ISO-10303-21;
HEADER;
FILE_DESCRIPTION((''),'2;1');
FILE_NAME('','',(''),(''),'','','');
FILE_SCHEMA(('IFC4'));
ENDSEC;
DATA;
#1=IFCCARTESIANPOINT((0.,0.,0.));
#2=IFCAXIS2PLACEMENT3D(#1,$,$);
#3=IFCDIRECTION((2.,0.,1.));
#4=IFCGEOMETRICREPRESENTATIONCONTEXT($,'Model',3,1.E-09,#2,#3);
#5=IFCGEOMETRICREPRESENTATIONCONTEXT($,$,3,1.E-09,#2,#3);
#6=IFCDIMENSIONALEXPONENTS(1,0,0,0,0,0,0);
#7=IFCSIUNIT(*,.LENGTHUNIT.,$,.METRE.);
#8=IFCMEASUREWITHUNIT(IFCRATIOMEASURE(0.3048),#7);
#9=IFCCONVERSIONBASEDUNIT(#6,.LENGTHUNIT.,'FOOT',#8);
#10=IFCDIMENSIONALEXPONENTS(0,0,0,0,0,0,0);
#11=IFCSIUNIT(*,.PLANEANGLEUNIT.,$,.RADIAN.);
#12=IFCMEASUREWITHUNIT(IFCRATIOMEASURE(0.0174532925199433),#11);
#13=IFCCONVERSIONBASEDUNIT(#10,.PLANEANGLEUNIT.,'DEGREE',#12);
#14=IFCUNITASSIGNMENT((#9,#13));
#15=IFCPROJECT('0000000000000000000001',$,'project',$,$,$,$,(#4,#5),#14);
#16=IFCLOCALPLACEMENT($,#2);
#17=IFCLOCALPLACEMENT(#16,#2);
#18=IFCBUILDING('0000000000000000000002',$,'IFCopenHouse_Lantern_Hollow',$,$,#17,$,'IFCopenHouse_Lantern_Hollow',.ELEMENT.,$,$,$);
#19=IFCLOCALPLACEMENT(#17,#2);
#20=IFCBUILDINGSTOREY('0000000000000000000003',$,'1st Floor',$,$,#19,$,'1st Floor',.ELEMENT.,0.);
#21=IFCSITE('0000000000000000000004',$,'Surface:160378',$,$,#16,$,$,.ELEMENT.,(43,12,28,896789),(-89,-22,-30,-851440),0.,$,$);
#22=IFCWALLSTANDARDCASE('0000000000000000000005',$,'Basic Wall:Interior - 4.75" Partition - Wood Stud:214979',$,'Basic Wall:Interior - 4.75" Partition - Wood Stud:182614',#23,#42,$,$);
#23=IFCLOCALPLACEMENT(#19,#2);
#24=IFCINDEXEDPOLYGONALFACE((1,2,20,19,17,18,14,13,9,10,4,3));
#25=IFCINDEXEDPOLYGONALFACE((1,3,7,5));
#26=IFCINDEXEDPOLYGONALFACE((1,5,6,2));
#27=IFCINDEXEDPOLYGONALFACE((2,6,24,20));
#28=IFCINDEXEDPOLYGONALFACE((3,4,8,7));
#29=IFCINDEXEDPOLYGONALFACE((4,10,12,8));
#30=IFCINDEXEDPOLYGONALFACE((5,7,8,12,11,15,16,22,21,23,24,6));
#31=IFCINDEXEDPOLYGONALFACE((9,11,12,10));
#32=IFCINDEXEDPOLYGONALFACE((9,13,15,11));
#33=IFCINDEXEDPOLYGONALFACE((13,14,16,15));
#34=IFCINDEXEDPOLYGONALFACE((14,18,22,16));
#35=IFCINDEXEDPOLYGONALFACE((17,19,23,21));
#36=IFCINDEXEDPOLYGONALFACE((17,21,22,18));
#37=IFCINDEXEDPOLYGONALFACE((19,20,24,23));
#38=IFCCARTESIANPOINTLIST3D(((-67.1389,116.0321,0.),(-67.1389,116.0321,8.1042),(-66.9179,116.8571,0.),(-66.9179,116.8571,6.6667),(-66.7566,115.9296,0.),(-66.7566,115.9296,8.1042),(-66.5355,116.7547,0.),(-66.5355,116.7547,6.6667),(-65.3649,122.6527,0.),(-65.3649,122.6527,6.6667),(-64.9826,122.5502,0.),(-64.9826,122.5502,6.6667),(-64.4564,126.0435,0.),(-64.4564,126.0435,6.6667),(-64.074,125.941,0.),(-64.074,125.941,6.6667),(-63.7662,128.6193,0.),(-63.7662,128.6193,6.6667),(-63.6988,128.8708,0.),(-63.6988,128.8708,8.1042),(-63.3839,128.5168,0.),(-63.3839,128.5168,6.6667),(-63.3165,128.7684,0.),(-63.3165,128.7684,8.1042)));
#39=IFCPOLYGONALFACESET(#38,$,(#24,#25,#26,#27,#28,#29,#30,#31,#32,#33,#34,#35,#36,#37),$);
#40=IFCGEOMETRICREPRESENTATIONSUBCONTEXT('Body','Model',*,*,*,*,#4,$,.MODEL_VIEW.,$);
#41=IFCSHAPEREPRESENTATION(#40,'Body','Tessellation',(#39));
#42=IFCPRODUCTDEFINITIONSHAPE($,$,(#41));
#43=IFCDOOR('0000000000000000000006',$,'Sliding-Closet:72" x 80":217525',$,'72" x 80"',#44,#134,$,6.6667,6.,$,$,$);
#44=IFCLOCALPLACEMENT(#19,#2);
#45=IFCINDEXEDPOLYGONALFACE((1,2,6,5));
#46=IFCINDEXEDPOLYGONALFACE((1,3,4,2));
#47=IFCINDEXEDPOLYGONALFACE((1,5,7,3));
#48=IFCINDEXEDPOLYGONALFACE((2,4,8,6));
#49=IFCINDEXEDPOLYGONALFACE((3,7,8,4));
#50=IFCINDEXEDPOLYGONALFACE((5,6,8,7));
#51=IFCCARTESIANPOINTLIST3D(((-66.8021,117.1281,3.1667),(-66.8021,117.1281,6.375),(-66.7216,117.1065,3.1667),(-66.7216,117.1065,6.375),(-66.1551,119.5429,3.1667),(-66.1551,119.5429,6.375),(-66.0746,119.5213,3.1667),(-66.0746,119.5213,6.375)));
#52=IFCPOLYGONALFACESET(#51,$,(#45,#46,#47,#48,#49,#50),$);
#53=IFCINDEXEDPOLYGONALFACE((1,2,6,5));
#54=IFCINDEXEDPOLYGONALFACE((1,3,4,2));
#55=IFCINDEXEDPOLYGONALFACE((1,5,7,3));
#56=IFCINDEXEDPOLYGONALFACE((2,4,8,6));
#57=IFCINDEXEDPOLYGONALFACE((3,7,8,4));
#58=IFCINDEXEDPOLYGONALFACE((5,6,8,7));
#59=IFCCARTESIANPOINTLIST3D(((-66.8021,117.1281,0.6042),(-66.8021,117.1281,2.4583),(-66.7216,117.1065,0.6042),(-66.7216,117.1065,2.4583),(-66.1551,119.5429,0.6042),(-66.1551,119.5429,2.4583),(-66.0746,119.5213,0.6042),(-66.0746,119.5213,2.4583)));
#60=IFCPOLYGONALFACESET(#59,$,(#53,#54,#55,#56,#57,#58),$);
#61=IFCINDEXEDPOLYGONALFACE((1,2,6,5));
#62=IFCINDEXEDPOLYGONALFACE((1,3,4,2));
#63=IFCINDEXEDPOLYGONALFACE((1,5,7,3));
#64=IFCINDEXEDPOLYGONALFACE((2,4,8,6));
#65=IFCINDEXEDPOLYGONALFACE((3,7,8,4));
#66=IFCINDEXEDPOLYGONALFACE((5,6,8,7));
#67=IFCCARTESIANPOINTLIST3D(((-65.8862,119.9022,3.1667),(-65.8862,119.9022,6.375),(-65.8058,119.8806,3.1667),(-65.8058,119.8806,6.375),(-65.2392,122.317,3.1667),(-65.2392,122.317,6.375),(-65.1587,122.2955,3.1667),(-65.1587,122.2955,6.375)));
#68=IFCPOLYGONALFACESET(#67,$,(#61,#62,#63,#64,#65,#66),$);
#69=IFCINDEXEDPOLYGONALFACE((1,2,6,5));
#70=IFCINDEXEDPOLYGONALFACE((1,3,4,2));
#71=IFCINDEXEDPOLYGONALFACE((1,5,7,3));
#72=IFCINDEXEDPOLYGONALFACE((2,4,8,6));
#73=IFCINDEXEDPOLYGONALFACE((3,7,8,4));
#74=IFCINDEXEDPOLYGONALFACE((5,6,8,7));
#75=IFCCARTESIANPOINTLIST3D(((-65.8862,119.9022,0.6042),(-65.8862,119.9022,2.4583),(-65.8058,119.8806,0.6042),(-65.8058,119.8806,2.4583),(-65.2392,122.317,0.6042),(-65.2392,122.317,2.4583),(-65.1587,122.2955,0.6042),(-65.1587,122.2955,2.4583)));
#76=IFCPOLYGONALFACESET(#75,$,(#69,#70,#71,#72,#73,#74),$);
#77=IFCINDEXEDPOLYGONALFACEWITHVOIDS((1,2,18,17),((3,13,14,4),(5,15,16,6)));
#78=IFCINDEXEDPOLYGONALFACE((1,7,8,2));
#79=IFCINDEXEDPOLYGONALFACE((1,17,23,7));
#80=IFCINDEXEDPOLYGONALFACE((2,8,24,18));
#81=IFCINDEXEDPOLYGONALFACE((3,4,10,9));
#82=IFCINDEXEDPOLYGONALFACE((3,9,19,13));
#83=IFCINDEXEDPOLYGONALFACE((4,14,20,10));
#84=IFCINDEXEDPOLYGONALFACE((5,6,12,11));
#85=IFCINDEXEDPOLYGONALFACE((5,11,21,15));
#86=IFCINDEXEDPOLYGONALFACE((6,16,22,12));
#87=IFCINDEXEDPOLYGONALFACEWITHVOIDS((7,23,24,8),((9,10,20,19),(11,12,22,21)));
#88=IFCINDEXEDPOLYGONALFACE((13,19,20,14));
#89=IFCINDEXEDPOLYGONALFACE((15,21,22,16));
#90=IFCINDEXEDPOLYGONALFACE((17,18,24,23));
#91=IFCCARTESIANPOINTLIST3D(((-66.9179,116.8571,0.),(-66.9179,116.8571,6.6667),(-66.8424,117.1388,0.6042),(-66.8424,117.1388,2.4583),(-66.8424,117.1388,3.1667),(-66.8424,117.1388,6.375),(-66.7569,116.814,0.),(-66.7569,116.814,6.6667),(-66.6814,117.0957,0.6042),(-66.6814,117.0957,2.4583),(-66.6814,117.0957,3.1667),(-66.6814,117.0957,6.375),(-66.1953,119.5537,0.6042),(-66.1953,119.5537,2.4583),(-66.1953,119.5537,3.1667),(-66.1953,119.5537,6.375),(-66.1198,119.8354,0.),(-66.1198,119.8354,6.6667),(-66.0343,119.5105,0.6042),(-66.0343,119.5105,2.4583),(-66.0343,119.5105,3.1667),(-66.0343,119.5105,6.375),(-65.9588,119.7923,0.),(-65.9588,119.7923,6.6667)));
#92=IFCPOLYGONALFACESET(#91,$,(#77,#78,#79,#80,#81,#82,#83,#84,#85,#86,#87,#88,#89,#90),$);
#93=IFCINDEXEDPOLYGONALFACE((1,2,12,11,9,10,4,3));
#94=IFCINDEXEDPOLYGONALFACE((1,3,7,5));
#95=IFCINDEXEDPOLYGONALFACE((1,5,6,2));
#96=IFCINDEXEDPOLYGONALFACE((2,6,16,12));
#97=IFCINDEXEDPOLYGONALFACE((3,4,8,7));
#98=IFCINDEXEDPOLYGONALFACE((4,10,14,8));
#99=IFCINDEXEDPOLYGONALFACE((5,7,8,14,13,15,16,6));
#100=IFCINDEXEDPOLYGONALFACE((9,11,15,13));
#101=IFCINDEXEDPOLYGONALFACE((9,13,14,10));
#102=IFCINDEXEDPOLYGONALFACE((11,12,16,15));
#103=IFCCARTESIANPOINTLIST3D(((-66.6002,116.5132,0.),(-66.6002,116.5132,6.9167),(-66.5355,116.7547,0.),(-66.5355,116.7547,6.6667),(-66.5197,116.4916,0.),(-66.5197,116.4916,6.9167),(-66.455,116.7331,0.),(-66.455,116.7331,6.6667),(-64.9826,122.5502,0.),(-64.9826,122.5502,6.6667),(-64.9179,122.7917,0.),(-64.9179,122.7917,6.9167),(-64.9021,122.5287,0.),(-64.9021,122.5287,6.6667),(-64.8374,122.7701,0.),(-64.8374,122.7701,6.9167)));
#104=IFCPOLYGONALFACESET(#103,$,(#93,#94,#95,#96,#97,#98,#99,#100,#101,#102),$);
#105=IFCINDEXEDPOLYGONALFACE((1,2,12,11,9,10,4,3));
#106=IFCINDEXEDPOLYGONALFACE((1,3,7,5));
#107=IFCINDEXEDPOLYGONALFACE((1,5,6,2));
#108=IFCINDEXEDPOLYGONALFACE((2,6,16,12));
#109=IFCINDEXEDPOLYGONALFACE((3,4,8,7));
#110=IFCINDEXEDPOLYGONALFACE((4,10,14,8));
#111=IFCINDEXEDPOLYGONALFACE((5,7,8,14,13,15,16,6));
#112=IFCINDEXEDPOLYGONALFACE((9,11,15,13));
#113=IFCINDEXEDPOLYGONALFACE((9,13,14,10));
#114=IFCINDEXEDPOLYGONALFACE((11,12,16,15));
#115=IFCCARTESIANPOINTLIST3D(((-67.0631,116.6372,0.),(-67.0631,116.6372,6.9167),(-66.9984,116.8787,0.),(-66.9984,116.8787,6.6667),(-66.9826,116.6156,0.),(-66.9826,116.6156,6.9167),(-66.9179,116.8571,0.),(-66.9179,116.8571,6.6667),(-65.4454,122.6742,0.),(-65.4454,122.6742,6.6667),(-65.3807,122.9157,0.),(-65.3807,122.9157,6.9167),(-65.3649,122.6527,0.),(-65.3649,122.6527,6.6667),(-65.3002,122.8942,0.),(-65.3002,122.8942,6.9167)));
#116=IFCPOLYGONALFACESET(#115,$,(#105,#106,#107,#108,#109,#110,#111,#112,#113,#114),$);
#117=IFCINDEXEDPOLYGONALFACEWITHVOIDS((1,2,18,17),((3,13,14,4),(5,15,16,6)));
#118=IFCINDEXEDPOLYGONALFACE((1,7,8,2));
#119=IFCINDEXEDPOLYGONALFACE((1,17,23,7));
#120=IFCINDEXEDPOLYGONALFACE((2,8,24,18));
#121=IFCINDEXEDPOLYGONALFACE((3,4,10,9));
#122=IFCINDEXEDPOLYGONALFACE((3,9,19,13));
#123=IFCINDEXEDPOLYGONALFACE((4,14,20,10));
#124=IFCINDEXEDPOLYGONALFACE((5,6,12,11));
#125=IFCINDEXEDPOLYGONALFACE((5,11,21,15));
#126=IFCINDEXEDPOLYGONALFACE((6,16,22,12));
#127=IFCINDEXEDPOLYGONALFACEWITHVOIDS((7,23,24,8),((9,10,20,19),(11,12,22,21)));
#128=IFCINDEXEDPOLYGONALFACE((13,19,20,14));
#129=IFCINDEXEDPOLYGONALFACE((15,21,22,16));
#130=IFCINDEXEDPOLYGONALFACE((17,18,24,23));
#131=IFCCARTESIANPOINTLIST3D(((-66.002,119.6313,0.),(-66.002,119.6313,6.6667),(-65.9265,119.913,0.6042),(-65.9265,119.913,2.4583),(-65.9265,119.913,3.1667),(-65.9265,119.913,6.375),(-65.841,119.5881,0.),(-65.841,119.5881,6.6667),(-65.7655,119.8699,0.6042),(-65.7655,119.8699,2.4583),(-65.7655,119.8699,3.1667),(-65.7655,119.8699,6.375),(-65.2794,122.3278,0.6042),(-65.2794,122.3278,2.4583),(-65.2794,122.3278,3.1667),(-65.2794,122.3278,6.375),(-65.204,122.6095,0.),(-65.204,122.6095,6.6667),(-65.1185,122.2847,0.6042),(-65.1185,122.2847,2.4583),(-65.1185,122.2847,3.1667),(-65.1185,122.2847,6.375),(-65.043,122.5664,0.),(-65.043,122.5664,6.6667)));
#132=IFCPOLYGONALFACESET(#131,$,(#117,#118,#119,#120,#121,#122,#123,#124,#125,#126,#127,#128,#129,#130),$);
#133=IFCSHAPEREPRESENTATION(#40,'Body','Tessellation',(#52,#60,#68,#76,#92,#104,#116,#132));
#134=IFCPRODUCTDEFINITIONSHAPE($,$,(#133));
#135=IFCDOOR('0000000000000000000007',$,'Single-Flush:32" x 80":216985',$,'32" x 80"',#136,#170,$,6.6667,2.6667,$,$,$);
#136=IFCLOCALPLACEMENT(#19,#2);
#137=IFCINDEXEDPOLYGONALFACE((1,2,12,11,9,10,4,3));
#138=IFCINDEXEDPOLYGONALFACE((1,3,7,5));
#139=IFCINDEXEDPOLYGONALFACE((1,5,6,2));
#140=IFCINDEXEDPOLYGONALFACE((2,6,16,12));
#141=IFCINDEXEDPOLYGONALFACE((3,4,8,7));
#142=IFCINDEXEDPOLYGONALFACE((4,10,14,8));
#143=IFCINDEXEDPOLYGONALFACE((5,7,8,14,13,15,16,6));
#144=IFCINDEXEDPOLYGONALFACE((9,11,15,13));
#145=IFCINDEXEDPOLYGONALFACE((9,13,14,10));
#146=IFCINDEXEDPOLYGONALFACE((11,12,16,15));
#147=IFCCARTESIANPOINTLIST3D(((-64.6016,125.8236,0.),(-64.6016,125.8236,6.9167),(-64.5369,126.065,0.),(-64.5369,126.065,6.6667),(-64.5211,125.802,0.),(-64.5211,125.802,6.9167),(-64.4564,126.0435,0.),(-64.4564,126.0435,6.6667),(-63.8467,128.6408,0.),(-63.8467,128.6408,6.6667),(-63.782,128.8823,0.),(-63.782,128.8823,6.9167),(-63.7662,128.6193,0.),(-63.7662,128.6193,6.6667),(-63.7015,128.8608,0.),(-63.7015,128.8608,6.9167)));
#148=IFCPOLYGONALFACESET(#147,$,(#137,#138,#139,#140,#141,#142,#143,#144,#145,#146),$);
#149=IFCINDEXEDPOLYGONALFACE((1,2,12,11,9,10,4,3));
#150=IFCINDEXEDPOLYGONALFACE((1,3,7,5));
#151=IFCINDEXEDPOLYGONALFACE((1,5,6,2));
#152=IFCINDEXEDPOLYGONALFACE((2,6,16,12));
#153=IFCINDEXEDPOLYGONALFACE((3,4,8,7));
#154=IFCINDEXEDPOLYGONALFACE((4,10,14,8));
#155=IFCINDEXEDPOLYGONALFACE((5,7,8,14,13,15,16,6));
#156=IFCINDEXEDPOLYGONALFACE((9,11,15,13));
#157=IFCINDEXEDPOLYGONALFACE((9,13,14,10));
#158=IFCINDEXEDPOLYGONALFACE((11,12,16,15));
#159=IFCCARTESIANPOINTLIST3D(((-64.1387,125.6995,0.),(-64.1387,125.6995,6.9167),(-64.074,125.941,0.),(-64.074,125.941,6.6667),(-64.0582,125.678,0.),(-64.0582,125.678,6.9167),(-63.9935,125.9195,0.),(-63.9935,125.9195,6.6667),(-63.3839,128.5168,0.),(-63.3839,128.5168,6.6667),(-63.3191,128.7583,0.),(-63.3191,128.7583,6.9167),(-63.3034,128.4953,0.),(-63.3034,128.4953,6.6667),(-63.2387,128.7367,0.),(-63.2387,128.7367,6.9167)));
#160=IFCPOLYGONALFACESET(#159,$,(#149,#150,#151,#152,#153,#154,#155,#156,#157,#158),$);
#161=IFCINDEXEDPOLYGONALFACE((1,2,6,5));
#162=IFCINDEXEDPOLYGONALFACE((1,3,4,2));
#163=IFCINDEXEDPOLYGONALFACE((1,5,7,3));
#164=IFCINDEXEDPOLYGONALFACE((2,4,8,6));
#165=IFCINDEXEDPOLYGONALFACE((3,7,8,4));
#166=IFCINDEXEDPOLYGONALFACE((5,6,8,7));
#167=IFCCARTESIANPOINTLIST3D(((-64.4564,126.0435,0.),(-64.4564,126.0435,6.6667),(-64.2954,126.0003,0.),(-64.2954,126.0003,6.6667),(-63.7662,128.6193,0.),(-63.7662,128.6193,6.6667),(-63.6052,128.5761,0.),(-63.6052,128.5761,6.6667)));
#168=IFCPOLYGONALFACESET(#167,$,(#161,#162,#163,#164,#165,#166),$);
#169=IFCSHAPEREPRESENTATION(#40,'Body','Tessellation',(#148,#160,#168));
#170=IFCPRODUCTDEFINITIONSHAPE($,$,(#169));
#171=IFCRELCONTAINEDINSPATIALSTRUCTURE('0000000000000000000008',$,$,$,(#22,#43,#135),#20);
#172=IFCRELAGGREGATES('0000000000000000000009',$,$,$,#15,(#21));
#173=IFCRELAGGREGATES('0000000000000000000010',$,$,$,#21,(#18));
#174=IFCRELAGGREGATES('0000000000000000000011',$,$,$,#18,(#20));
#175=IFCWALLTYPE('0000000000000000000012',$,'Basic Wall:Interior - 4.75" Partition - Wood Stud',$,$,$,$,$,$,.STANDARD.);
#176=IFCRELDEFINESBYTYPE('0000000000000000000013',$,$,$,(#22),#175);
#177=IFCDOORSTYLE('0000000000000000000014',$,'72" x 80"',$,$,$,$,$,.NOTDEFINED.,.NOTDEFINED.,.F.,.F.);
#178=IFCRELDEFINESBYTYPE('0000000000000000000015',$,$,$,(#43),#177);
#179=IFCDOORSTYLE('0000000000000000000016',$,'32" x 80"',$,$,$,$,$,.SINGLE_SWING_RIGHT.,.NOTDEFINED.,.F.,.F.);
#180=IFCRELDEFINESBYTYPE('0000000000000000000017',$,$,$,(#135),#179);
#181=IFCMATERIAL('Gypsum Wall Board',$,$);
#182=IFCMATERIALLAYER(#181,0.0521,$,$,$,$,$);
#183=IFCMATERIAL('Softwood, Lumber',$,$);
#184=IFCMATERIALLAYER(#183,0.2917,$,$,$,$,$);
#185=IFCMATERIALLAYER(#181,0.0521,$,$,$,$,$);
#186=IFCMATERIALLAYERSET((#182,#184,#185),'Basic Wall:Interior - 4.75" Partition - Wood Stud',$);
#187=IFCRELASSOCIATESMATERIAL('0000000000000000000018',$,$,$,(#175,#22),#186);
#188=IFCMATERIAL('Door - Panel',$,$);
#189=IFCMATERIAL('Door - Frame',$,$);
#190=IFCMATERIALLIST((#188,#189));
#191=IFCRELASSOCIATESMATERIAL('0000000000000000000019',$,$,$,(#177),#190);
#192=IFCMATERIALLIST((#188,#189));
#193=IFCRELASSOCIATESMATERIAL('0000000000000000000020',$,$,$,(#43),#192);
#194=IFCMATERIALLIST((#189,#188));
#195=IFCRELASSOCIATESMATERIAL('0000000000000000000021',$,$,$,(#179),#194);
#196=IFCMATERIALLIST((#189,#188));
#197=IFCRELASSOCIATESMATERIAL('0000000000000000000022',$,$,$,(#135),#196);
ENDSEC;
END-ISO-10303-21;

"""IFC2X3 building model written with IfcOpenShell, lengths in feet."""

from ifc_helpers import new_model, entity, si_unit, converted_unit, direction, frame, frame_2d, origin, origin_2d_with_axis, place, context, subcontext, project, spatial, polyline, rectangle, outline, extrude, source, transform, mapped, material, material_list, layer, layer_set, layer_usage, type_object, type_shapes, element, fill, save


model = new_model("IFC2X3")

# Units and contexts
model_context = context("Model", 3, precision=1e-09, world=origin(), true_north=direction((2.0, 0.0, 1.0)))
context_of_model = context(None, 3, precision=1e-09, world=origin(), true_north=direction((2.0, 0.0, 1.0)))
body_context = subcontext(model_context, "Body", "Model", "MODEL_VIEW")
ifc_project = project(units=[converted_unit("LENGTHUNIT", "FOOT", entity("IfcRatioMeasure", 0.3048), si_unit("LENGTHUNIT", "METRE"), dimensions=[1, 0, 0, 0, 0, 0, 0]), converted_unit("PLANEANGLEUNIT", "DEGREE", entity("IfcRatioMeasure", 0.0174532925199433), si_unit("PLANEANGLEUNIT", "RADIAN"), dimensions=[0, 0, 0, 0, 0, 0, 0])], contexts=[model_context, context_of_model])

# Site, building, storey
site_placement = place(None, origin())
site = spatial("IfcSite", under=ifc_project, at=site_placement, Name="Surface:160378", CompositionType="ELEMENT", RefLatitude=(43, 12, 28, 896789), RefLongitude=(-89, -22, -30, -851440), RefElevation=0.0)
building_placement = place(site_placement, origin())
building = spatial("IfcBuilding", under=site, at=building_placement, Name="IFCopenHouse_Lantern_Hollow", LongName="IFCopenHouse_Lantern_Hollow", CompositionType="ELEMENT")
storey_placement = place(building_placement, origin())
storey = spatial("IfcBuildingStorey", under=building, at=storey_placement, Name="1st Floor", LongName="1st Floor", CompositionType="ELEMENT", Elevation=0.0)

# Shared definitions
ifc_material_1 = material(Name="Softwood, Lumber")

# Shared definitions
ifc_material_2 = material(Name="Gypsum Wall Board")

# Shared definitions
ifc_layer_1 = layer(ifc_material_2, 0.0521)
ifc_layer_2 = layer(ifc_material_1, 0.2917)
ifc_layer_3 = layer(ifc_material_2, 0.0521)
ifc_layer_set_1 = layer_set([ifc_layer_1, ifc_layer_2, ifc_layer_3], Name="Basic Wall:Interior - 4.75\" Partition - Wood Stud")
wall_type_1 = type_object("IfcWallType", Name="Basic Wall:Interior - 4.75\" Partition - Wood Stud", PredefinedType="STANDARD", material=ifc_layer_set_1)

# Shared definitions
ifc_material_3 = material(Name="Door - Panel")
ifc_material_4 = material(Name="Door - Frame")
ifc_material_list_1 = material_list([ifc_material_3, ifc_material_4])
door_style_1 = type_object("IfcDoorStyle", Name="72\" x 80\"", ConstructionType="NOTDEFINED", OperationType="NOTDEFINED", ParameterTakesPrecedence=False, Sizeable=False, material=ifc_material_list_1)
shared_shape_1 = source(origin(), body_context, "Body", "SweptSolid", [
    extrude(rectangle(XDim=0.0833, YDim=2.5, at=origin_2d_with_axis()), frame((1.5417, 0.3125, 3.1667), z_axis=(0.0, 0.0, 1.0), x_axis=(0.0, 1.0, 0.0)), (0.0, 0.0, 1.0), 3.2083),
    extrude(rectangle(XDim=0.0833, YDim=2.5, at=origin_2d_with_axis()), frame((1.5417, 0.3125, 0.6042), z_axis=(0.0, 0.0, 1.0), x_axis=(0.0, 1.0, 0.0)), (0.0, 0.0, 1.0), 1.8542),
    extrude(rectangle(XDim=0.0833, YDim=2.5, at=origin_2d_with_axis()), frame((4.4583, 0.1458, 3.1667), z_axis=(0.0, 0.0, 1.0), x_axis=(0.0, -1.0, 0.0)), (0.0, 0.0, 1.0), 3.2083),
    extrude(rectangle(XDim=0.0833, YDim=2.5, at=origin_2d_with_axis()), frame((4.4583, 0.1458, 0.6042), z_axis=(0.0, 0.0, 1.0), x_axis=(0.0, -1.0, 0.0)), (0.0, 0.0, 1.0), 1.8542),
    extrude(outline(polyline([(-3.3333, -1.5417), (3.3333, -1.5417), (3.3333, 1.5417), (-3.3333, 1.5417), (-3.3333, -1.5417)]), holes=[polyline([(2.7292, 1.25), (2.7292, -1.25), (0.875, -1.25), (0.875, 1.25), (2.7292, 1.25)]), polyline([(0.1667, 1.25), (0.1667, -1.25), (-3.0417, -1.25), (-3.0417, 1.25), (0.1667, 1.25)])]), frame((1.5417, 0.2292, 3.3333), z_axis=(0.0, 1.0, 0.0), x_axis=(0.0, 0.0, -1.0)), (0.0, 0.0, 1.0), 0.1667),
    extrude(outline(polyline([(-3.3958, -3.25), (3.5208, -3.25), (3.5208, 3.25), (-3.3958, 3.25), (-3.3958, 3.0), (3.2708, 3.0), (3.2708, -3.0), (-3.3958, -3.0), (-3.3958, -3.25)])), frame((3.0, -0.0833, 3.3958), z_axis=(0.0, 1.0, 0.0), x_axis=(0.0, 0.0, 1.0)), (0.0, 0.0, 1.0), 0.0833),
    extrude(outline(polyline([(-3.25, -3.3958), (-3.0, -3.3958), (-3.0, 3.2708), (3.0, 3.2708), (3.0, -3.3958), (3.25, -3.3958), (3.25, 3.5208), (-3.25, 3.5208), (-3.25, -3.3958)])), frame((3.0, 0.3958, 3.3958), z_axis=(0.0, 1.0, 0.0), x_axis=(-1.0, 0.0, 0.0)), (0.0, 0.0, 1.0), 0.0833),
    extrude(outline(polyline([(-1.5417, -3.3333), (1.5417, -3.3333), (1.5417, 3.3333), (-1.5417, 3.3333), (-1.5417, -3.3333)]), holes=[polyline([(1.25, 0.1667), (1.25, -3.0417), (-1.25, -3.0417), (-1.25, 0.1667), (1.25, 0.1667)]), polyline([(1.25, 2.7292), (1.25, 0.875), (-1.25, 0.875), (-1.25, 2.7292), (1.25, 2.7292)])]), frame((4.4583, 0.0625, 3.3333), z_axis=(0.0, 1.0, 0.0), x_axis=(1.0, 0.0, 0.0)), (0.0, 0.0, 1.0), 0.1667),
])
type_shapes(door_style_1, [shared_shape_1])

# Wall, openings, doors
ifc_layer_usage_1 = layer_usage(ifc_layer_set_1, "AXIS2", "NEGATIVE", 0.1979)
wall_1_placement = place(storey_placement, frame((-66.9478, 115.9808, 0.0), z_axis=(0.0, 0.0, 1.0), x_axis=(0.258819, 0.965926, 0.0)))
wall_1 = element("IfcWallStandardCase", 1, at=wall_1_placement, inside=storey, type_object=wall_type_1, material=ifc_layer_usage_1, Name="Basic Wall:Interior - 4.75\" Partition - Wood Stud:214979", ObjectType="Basic Wall:Interior - 4.75\" Partition - Wood Stud:182614", context=body_context, shape_type="SweptSolid", body=[
    extrude(rectangle(XDim=13.2917, YDim=0.3958, at=frame_2d((6.6458, 0.0), x_axis=(-1.0, 0.0))), origin(), (0.0, 0.0, 1.0), 8.1042),
])
opening_1_placement = place(wall_1_placement, frame((10.3646, -0.1979, 0.0)))
opening_1 = element("IfcOpeningElement", 2, at=opening_1_placement, cuts=wall_1, ObjectType="Opening", context=body_context, shape_type="SweptSolid", body=[
    extrude(rectangle(XDim=2.6667, YDim=6.6667, at=frame_2d((3.3333, 1.3333), x_axis=(0.0, 1.0))), frame((0.0, 0.0, 0.0), z_axis=(0.0, 1.0, 0.0), x_axis=(0.0, 0.0, 1.0)), (0.0, 0.0, 1.0), 0.3958),
])
opening_2_placement = place(wall_1_placement, frame((0.8542, -0.1979, 0.0)))
opening_2 = element("IfcOpeningElement", 3, at=opening_2_placement, cuts=wall_1, ObjectType="Opening", context=body_context, shape_type="SweptSolid", body=[
    extrude(rectangle(XDim=6.6667, YDim=6.0, at=frame_2d((3.3333, 3.0), x_axis=(-1.0, 0.0))), frame((0.0, 0.0, 0.0), z_axis=(0.0, 1.0, 0.0), x_axis=(0.0, 0.0, 1.0)), (0.0, 0.0, 1.0), 0.3958),
])
ifc_material_list_2 = material_list([ifc_material_3, ifc_material_4])
door_1_placement = place(storey_placement, frame((-66.5355, 116.7547, 0.0), z_axis=(0.0, 0.0, 1.0), x_axis=(0.258819, 0.965926, 0.0)))
door_1 = element("IfcDoor", 4, at=door_1_placement, inside=storey, type_object=door_style_1, material=ifc_material_list_2, Name="Sliding-Closet:72\" x 80\":217525", ObjectType="72\" x 80\"", OverallHeight=6.6667, OverallWidth=6.0, context=body_context, shape_type="MappedRepresentation", body=[
    mapped(shared_shape_1, transform((0.0, 0.0, 0.0), scale=1.0)),
])
fill(opening_2, door_1)
ifc_material_list_3 = material_list([ifc_material_4, ifc_material_3])
ifc_material_list_4 = material_list([ifc_material_4, ifc_material_3])
door_style_2 = type_object("IfcDoorStyle", Name="32\" x 80\"", ConstructionType="NOTDEFINED", OperationType="SINGLE_SWING_RIGHT", ParameterTakesPrecedence=False, Sizeable=False, material=ifc_material_list_4)
shared_shape_2 = source(origin(), body_context, "Body", "SweptSolid", [
    extrude(outline(polyline([(-1.5833, -3.5208), (1.5833, -3.5208), (1.5833, 3.3958), (1.3333, 3.3958), (1.3333, -3.2708), (-1.3333, -3.2708), (-1.3333, 3.3958), (-1.5833, 3.3958), (-1.5833, -3.5208)])), frame((1.3333, 0.3958, 3.3958), z_axis=(0.0, 1.0, 0.0), x_axis=(1.0, 0.0, 0.0)), (0.0, 0.0, 1.0), 0.0833),
    extrude(outline(polyline([(-3.5208, -1.5833), (3.3958, -1.5833), (3.3958, -1.3333), (-3.2708, -1.3333), (-3.2708, 1.3333), (3.3958, 1.3333), (3.3958, 1.5833), (-3.5208, 1.5833), (-3.5208, -1.5833)])), frame((1.3333, -0.0833, 3.3958), z_axis=(0.0, 1.0, 0.0), x_axis=(0.0, 0.0, -1.0)), (0.0, 0.0, 1.0), 0.0833),
    extrude(rectangle(XDim=0.1667, YDim=2.6667, at=frame_2d((0.0, 0.0), x_axis=(1.0, 0.0))), frame((1.3333, 0.3125, 0.0), z_axis=(0.0, 0.0, 1.0), x_axis=(0.0, 1.0, 0.0)), (0.0, 0.0, 1.0), 6.6667),
])
type_shapes(door_style_2, [shared_shape_2])
door_2_placement = place(storey_placement, frame((-64.074, 125.941, 0.0), z_axis=(0.0, 0.0, 1.0), x_axis=(0.258819, 0.965926, 0.0)))
door_2 = element("IfcDoor", 5, at=door_2_placement, inside=storey, type_object=door_style_2, material=ifc_material_list_3, Name="Single-Flush:32\" x 80\":216985", ObjectType="32\" x 80\"", OverallHeight=6.6667, OverallWidth=2.6667, context=body_context, shape_type="MappedRepresentation", body=[
    mapped(shared_shape_2, transform((0.0, 0.0, 0.0), scale=1.0)),
])
fill(opening_1, door_2)

save(model, "model.ifc")
